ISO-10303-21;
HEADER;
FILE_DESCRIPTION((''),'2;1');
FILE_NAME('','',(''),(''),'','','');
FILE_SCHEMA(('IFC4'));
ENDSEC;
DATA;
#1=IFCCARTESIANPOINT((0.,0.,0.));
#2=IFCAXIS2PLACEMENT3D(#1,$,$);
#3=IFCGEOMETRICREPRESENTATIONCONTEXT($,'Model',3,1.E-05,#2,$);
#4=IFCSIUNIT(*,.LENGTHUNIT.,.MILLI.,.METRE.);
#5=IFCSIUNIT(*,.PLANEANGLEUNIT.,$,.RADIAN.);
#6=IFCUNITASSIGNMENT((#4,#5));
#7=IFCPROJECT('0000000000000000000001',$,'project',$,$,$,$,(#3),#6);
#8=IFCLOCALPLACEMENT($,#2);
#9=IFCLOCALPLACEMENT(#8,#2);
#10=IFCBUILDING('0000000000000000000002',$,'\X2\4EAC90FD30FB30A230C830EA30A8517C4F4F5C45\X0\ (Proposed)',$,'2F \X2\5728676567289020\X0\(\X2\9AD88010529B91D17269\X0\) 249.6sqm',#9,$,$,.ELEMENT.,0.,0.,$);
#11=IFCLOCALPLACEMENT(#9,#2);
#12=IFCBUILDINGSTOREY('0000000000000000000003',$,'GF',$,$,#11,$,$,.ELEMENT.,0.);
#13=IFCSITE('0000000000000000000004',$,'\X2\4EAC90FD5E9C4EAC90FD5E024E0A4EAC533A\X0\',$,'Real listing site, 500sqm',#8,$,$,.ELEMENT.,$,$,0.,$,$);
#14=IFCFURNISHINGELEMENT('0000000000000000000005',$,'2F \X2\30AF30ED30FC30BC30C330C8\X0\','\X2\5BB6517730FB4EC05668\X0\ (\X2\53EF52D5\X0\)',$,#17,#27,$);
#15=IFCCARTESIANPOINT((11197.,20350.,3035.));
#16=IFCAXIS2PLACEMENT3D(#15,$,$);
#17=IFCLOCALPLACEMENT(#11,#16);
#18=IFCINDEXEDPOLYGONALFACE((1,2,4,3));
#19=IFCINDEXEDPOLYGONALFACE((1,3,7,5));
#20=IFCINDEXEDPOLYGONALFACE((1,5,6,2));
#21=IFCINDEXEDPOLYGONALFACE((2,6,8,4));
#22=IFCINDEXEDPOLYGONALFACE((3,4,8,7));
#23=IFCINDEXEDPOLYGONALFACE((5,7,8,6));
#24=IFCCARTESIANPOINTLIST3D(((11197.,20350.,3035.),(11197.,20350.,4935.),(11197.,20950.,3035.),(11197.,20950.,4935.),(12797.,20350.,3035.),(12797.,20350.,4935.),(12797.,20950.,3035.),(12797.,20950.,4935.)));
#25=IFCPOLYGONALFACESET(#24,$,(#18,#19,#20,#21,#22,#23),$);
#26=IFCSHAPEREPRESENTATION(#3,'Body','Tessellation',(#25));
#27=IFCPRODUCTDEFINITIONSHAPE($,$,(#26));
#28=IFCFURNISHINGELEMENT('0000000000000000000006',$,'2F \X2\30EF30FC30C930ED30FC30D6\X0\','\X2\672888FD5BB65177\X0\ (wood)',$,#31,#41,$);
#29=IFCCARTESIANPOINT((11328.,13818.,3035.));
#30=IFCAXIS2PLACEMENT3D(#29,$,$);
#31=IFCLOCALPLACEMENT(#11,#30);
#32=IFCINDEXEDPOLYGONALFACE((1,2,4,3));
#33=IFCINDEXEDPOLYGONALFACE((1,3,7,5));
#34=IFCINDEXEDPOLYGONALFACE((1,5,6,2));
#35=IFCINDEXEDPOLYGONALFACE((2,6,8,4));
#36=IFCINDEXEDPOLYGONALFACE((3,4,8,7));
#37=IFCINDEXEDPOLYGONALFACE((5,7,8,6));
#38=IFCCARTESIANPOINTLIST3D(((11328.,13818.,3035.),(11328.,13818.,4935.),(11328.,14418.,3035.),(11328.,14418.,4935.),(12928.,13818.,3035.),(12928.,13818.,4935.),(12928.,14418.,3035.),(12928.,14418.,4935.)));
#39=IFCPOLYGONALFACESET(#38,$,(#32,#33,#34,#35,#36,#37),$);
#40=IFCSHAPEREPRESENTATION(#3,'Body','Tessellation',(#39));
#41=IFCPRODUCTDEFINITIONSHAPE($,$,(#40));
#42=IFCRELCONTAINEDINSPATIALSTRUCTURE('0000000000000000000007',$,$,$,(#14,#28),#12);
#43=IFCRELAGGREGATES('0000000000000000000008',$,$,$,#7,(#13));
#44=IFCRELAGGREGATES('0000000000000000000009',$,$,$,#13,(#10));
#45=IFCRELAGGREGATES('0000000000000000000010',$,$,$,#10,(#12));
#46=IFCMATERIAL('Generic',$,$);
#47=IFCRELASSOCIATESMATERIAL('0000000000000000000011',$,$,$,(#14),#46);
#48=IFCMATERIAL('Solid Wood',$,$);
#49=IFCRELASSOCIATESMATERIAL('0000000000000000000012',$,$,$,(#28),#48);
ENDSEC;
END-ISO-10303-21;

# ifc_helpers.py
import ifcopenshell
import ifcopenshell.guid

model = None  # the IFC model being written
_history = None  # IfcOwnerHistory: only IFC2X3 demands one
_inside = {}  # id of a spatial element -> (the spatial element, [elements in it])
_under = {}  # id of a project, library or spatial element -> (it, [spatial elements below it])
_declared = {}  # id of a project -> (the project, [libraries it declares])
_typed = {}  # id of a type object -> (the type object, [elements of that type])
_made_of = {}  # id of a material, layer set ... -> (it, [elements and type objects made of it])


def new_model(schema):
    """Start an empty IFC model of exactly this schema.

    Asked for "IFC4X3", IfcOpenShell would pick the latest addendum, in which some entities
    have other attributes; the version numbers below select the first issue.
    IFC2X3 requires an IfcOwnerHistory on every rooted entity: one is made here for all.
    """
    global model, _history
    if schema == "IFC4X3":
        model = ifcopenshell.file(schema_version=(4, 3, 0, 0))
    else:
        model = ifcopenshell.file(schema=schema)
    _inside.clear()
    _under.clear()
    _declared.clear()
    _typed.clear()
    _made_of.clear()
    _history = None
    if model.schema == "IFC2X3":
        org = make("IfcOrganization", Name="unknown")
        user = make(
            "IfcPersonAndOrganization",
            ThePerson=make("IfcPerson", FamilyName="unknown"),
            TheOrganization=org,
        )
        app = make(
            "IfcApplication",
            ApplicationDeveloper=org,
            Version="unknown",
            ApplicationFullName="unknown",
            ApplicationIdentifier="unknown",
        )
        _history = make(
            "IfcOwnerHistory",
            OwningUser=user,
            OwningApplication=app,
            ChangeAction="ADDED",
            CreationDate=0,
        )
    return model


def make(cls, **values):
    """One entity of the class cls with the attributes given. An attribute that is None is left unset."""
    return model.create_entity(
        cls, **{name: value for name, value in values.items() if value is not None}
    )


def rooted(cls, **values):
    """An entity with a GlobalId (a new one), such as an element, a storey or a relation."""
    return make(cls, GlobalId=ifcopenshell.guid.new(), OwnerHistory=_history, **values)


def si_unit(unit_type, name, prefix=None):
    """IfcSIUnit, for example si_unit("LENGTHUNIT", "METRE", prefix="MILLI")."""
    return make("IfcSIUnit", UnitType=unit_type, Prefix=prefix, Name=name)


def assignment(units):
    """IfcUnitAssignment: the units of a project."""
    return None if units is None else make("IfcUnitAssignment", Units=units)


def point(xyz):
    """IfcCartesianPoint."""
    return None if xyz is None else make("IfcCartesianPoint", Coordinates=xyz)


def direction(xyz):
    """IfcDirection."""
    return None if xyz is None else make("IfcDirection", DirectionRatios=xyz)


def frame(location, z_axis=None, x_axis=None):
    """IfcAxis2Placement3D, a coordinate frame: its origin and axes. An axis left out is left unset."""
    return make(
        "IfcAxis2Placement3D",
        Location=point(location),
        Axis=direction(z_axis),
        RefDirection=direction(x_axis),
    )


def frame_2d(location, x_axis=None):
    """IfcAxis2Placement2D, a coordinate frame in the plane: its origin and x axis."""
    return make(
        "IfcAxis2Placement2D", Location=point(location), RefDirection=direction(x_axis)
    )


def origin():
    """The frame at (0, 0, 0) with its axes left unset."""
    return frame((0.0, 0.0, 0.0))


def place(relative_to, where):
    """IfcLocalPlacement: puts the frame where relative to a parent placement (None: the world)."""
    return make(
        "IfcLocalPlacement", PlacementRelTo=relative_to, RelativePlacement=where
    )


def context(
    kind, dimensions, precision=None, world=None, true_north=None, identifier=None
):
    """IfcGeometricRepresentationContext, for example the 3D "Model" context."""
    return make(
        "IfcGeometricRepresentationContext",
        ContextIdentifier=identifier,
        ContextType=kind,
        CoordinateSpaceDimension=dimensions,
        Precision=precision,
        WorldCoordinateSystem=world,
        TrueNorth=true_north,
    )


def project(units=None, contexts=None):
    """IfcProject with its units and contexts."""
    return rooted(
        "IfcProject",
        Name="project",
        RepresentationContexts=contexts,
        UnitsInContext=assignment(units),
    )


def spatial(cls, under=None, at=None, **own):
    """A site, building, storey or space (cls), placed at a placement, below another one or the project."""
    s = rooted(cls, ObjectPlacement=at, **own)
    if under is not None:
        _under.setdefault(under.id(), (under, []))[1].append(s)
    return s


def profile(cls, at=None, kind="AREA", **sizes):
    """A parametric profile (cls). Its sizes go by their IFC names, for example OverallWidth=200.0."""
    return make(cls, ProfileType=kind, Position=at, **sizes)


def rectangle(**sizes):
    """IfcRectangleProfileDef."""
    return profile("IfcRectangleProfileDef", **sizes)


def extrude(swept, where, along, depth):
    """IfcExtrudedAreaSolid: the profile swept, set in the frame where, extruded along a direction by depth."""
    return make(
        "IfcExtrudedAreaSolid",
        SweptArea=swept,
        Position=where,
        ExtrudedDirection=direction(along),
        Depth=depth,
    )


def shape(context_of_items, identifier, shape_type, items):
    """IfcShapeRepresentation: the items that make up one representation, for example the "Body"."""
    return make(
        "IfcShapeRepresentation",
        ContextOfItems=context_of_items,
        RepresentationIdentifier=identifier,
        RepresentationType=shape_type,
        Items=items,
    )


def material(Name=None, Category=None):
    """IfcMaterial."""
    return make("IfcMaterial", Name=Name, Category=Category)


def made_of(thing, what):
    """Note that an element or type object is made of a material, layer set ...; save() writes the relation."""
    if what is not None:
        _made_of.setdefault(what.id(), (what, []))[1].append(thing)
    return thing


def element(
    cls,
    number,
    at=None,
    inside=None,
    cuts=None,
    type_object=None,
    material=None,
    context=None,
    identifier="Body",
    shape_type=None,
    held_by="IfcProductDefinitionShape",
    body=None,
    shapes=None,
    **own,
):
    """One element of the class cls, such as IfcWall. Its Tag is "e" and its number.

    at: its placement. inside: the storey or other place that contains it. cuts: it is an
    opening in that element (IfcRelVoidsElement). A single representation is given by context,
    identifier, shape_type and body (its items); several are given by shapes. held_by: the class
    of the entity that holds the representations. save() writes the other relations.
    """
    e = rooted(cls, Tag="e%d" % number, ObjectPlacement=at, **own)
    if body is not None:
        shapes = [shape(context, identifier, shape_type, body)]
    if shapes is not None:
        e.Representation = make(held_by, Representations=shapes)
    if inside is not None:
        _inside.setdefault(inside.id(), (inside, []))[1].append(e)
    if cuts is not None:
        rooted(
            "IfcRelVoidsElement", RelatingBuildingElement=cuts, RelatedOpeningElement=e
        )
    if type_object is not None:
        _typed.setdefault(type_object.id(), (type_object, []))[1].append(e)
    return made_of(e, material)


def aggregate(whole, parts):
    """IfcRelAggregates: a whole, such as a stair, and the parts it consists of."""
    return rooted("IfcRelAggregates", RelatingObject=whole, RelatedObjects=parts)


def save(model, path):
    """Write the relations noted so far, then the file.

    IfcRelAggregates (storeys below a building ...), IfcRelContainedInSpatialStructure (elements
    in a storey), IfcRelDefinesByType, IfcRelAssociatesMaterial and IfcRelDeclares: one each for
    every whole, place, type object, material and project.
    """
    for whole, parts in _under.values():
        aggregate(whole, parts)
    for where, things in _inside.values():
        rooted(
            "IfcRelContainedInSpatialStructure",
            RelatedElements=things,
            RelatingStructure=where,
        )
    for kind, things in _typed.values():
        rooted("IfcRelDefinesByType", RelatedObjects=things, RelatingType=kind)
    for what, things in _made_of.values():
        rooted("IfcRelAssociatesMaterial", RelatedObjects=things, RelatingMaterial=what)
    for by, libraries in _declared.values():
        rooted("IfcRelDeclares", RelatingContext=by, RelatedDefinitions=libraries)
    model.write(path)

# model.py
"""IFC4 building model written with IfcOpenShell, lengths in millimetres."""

from ifc_helpers import new_model, si_unit, frame, frame_2d, origin, place, context, project, spatial, rectangle, extrude, material, element, save


model = new_model("IFC4")

# Units and contexts
model_context = context("Model", 3, precision=1e-05, world=origin())
ifc_project = project(units=[si_unit("LENGTHUNIT", "METRE", prefix="MILLI"), si_unit("PLANEANGLEUNIT", "RADIAN")], contexts=[model_context])

# Site, building, storey
site_placement = place(None, origin())
site = spatial("IfcSite", under=ifc_project, at=site_placement, Name="京都府京都市上京区", ObjectType="Real listing site, 500sqm", CompositionType="ELEMENT", RefElevation=0.0)
building_placement = place(site_placement, origin())
building = spatial("IfcBuilding", under=site, at=building_placement, Name="京都・アトリエ兼住居 (Proposed)", ObjectType="2F 在来木造(高耐力金物) 249.6sqm", CompositionType="ELEMENT", ElevationOfRefHeight=0.0, ElevationOfTerrain=0.0)
storey_placement = place(building_placement, origin())
storey = spatial("IfcBuildingStorey", under=building, at=storey_placement, Name="GF", CompositionType="ELEMENT", Elevation=0.0)

# Shared definitions
ifc_material_1 = material(Name="Solid Wood")

# Shared definitions
ifc_material_2 = material(Name="Generic")

# Furnishing elements
furnishing_1_placement = place(storey_placement, frame((11197.0, 20350.0, 3035.0)))
element("IfcFurnishingElement", 1, at=furnishing_1_placement, inside=storey, material=ifc_material_2, Name="2F クローゼット", Description="家具・什器 (可動)", context=model_context, shape_type="SweptSolid", body=[
    extrude(rectangle(XDim=1600.0, YDim=600.0, at=frame_2d((800.0, 300.0))), frame((11197.0, 20350.0, 3035.0)), (0.0, 0.0, 1.0), 1900.0),
])
furnishing_2_placement = place(storey_placement, frame((11328.0, 13818.0, 3035.0)))
element("IfcFurnishingElement", 2, at=furnishing_2_placement, inside=storey, material=ifc_material_1, Name="2F ワードローブ", Description="木製家具 (wood)", context=model_context, shape_type="SweptSolid", body=[
    extrude(rectangle(XDim=1600.0, YDim=600.0, at=frame_2d((800.0, 300.0))), frame((11328.0, 13818.0, 3035.0)), (0.0, 0.0, 1.0), 1900.0),
])

save(model, "model.ifc")
